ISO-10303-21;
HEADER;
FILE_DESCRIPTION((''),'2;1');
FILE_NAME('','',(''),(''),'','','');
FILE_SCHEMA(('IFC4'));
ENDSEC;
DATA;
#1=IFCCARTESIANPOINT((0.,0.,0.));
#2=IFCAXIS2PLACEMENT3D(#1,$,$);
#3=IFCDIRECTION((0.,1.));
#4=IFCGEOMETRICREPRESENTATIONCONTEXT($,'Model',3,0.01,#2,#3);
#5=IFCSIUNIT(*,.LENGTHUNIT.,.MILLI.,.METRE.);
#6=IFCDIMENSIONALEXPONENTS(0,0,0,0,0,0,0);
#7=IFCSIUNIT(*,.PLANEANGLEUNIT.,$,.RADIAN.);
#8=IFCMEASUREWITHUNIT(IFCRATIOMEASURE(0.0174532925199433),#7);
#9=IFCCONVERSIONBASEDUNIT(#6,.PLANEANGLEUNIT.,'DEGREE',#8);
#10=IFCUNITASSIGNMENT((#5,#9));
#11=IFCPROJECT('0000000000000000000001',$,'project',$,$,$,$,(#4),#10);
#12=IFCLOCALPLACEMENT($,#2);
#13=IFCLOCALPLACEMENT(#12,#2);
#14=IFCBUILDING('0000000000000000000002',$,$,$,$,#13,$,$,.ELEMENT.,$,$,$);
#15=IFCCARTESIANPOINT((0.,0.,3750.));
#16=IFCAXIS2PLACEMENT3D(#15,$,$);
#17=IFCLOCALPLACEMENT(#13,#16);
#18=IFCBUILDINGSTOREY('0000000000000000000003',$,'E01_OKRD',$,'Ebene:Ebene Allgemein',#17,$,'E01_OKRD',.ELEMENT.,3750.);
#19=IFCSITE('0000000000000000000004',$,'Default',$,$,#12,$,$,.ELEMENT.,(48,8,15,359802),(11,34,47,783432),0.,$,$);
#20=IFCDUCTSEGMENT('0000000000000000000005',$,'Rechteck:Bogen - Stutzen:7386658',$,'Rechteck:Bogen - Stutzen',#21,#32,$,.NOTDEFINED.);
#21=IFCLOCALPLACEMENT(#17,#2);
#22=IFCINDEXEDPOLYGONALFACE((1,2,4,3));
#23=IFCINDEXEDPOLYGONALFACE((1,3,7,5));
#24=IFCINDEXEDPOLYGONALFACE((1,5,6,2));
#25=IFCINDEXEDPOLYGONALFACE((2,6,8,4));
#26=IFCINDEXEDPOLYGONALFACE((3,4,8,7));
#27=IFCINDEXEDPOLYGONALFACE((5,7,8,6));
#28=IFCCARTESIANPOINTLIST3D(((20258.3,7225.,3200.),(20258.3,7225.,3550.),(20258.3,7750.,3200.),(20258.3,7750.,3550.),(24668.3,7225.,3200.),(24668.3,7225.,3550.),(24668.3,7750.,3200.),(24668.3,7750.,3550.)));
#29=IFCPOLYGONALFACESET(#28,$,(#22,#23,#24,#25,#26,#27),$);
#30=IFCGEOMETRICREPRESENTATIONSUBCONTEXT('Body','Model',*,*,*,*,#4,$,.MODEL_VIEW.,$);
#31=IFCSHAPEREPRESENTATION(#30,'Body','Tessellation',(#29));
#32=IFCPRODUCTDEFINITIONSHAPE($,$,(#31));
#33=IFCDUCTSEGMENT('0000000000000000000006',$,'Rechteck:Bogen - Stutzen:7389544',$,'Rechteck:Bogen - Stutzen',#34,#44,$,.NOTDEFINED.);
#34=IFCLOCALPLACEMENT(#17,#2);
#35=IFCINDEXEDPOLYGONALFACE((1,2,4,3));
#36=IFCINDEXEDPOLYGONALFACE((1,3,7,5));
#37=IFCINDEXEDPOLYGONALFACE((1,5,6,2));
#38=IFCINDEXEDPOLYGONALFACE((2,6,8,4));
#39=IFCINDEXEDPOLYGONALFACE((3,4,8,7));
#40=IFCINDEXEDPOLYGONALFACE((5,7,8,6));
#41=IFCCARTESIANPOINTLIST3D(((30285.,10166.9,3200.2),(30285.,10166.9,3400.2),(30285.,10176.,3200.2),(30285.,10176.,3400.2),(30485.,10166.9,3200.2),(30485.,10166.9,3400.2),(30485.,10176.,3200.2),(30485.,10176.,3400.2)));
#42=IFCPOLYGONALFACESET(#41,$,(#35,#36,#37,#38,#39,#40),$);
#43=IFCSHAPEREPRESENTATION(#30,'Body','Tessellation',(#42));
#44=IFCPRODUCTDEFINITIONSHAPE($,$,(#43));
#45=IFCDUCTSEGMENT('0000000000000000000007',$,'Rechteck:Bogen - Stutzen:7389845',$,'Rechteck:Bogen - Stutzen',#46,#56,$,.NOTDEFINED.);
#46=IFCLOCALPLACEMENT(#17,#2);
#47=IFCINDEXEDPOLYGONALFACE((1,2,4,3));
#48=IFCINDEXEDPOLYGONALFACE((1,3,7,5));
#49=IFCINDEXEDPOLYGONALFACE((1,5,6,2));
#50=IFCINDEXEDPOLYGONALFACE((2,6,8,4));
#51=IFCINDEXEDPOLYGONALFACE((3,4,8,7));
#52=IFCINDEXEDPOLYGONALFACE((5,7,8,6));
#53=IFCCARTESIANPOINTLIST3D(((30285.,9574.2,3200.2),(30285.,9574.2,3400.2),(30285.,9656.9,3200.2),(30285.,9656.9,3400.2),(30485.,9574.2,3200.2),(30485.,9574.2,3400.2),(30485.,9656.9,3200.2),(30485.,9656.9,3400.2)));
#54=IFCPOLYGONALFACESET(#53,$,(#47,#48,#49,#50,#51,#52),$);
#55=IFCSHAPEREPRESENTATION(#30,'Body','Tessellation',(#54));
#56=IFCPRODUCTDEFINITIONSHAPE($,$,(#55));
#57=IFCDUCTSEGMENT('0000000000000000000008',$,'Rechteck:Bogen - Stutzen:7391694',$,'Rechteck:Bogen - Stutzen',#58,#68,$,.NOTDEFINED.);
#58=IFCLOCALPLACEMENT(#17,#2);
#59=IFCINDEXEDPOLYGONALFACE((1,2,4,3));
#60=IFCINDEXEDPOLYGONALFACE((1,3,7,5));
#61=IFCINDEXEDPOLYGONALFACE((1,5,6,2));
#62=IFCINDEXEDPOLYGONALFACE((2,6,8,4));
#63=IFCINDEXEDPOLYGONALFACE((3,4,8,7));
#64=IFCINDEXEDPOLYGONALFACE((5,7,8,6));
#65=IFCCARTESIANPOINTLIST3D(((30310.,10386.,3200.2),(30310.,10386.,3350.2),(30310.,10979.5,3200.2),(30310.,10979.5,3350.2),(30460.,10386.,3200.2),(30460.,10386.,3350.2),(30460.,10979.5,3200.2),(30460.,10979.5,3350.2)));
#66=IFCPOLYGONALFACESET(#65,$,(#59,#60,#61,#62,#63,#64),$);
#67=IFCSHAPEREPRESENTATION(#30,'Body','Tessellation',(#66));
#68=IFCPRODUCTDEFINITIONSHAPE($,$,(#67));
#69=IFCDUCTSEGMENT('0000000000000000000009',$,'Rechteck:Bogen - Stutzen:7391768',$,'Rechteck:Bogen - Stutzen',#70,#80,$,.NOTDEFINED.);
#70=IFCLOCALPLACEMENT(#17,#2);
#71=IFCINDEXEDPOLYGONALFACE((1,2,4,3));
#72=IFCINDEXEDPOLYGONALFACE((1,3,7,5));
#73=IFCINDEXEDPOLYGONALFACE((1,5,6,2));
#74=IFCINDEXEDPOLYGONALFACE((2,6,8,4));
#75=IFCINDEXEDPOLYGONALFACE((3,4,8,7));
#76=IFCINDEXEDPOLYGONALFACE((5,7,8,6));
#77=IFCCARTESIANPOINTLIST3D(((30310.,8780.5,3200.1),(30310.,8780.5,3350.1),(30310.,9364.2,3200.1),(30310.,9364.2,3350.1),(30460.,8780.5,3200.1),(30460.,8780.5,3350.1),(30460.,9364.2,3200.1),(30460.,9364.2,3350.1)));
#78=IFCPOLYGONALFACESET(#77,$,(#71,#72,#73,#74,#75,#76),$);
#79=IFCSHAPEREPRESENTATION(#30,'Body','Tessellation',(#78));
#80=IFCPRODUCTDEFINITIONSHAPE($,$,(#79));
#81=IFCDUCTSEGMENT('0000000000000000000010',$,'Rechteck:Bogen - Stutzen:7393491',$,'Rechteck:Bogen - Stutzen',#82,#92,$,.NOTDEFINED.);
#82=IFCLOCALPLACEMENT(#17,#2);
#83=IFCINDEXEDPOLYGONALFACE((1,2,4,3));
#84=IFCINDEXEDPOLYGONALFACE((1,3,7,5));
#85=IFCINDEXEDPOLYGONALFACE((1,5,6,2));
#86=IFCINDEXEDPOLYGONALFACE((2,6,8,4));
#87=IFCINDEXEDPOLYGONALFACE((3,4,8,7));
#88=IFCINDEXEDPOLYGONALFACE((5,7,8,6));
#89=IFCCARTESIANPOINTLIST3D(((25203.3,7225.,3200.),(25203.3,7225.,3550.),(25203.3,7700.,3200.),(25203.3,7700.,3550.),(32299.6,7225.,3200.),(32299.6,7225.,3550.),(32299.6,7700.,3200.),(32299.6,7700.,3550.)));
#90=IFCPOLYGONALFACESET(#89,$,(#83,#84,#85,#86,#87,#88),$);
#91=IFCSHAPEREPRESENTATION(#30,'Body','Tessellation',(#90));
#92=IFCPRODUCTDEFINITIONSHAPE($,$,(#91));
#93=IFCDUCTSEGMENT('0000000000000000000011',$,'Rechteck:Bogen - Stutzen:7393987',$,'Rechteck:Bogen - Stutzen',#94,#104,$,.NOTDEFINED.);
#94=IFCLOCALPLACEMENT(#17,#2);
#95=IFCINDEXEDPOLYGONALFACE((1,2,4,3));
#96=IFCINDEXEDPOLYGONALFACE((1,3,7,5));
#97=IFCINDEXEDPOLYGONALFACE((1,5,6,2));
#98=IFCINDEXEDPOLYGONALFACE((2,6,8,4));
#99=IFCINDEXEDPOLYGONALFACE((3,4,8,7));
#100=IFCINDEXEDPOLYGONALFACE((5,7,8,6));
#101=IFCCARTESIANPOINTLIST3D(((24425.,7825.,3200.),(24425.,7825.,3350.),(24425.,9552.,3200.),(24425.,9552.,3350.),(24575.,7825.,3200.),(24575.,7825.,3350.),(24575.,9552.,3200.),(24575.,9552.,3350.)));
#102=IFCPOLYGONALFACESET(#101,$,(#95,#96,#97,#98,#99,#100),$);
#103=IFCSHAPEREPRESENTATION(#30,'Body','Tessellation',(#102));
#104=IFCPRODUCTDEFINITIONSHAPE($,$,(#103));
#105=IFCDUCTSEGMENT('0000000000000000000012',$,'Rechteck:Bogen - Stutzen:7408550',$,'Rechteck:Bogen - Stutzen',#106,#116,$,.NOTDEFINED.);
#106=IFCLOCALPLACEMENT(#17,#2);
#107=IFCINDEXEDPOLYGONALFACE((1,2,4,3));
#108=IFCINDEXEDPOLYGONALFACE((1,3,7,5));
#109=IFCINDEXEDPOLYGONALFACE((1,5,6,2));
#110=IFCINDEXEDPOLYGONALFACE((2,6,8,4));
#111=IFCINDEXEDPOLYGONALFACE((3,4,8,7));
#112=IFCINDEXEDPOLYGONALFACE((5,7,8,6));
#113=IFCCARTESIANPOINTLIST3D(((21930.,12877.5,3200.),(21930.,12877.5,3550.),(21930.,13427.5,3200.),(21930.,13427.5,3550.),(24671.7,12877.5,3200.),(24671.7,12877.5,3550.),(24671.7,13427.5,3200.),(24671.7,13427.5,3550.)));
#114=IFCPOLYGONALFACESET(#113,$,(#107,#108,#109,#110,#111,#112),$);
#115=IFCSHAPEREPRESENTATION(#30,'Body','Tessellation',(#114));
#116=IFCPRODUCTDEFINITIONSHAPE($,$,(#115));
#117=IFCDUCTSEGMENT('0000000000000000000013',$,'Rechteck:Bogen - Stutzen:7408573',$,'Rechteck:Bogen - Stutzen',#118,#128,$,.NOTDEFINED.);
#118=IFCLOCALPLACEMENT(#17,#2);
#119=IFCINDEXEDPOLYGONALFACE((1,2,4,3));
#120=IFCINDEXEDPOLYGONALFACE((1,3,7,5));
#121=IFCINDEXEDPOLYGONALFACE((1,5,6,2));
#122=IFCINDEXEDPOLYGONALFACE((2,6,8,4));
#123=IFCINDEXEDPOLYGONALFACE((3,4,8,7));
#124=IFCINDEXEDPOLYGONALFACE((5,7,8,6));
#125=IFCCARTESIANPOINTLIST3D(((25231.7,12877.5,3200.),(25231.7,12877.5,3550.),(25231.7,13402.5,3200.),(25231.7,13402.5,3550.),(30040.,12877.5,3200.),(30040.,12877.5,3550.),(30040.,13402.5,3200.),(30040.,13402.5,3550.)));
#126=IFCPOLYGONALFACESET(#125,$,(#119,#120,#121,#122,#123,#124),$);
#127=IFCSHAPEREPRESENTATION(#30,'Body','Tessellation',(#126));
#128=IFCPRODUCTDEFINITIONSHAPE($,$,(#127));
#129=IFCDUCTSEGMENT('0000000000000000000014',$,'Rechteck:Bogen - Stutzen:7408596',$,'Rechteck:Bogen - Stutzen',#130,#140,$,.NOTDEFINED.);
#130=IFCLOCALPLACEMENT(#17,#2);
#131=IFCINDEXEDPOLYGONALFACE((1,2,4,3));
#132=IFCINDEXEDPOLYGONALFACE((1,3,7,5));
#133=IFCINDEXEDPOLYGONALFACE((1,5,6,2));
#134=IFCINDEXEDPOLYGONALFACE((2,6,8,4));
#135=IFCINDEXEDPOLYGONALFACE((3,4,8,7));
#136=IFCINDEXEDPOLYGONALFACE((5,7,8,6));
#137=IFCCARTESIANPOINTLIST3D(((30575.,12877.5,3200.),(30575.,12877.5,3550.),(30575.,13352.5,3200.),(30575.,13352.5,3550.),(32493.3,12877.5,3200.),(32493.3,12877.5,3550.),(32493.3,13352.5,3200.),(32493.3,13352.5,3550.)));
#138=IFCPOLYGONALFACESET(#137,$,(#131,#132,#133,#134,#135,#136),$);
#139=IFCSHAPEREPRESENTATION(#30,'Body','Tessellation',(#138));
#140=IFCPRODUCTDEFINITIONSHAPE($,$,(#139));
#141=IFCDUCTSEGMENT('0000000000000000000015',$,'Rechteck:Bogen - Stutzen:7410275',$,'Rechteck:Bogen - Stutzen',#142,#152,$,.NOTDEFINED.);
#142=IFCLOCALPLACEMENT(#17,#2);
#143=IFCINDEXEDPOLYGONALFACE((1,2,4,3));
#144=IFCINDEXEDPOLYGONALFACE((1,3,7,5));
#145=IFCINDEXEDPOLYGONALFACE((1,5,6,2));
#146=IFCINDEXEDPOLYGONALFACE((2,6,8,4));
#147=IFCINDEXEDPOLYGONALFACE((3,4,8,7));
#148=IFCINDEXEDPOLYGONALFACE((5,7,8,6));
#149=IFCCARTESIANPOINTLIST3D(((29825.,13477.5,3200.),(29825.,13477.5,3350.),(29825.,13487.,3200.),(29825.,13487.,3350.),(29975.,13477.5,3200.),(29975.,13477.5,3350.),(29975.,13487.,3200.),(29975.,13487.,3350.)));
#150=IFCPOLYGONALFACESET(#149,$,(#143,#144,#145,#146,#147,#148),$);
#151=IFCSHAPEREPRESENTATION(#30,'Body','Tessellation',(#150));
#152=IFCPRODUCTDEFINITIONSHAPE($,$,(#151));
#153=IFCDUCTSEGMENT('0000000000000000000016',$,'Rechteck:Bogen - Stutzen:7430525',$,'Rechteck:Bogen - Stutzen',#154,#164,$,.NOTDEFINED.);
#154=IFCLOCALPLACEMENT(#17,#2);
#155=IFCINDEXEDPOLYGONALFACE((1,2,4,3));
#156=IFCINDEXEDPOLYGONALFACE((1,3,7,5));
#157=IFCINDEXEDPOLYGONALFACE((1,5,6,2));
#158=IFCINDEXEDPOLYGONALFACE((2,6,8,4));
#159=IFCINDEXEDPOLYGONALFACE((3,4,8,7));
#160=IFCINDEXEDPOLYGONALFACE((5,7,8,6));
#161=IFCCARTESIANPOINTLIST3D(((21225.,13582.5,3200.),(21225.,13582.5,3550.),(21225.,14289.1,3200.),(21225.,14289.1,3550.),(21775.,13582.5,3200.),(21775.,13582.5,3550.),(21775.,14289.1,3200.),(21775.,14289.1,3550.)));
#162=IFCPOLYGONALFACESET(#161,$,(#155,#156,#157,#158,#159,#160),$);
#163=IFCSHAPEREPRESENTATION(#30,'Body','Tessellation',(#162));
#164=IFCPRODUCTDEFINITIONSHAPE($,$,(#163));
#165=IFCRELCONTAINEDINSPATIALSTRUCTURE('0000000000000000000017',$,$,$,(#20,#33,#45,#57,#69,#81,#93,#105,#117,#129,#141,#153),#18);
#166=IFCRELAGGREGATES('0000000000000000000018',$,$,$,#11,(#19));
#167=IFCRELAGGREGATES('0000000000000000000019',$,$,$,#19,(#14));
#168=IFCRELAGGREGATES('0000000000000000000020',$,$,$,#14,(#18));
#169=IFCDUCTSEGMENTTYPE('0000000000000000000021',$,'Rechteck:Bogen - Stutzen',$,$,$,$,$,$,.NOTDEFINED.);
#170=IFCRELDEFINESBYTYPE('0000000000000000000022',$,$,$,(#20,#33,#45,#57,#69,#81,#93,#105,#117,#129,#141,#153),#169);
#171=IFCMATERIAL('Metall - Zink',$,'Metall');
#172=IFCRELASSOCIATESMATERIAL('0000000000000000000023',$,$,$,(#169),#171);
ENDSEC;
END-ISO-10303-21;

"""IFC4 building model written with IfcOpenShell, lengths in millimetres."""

from ifc_helpers import new_model, entity, si_unit, converted_unit, direction, frame, frame_2d, origin, origin_2d_with_axis, place, context, subcontext, project, spatial, rectangle, extrude, material, type_object, element, save


model = new_model("IFC4")

# Units and contexts
model_context = context("Model", 3, precision=0.01, world=origin(), true_north=direction((0.0, 1.0)))
body_context = subcontext(model_context, "Body", "Model", "MODEL_VIEW")
ifc_project = project(units=[si_unit("LENGTHUNIT", "METRE", prefix="MILLI"), converted_unit("PLANEANGLEUNIT", "DEGREE", entity("IfcRatioMeasure", 0.0174532925199433), si_unit("PLANEANGLEUNIT", "RADIAN"), dimensions=[0, 0, 0, 0, 0, 0, 0])], contexts=[model_context])

# Site, building, storey
site_placement = place(None, origin())
site = spatial("IfcSite", under=ifc_project, at=site_placement, Name="Default", CompositionType="ELEMENT", RefLatitude=(48, 8, 15, 359802), RefLongitude=(11, 34, 47, 783432), RefElevation=0.0)
building_placement = place(site_placement, origin())
building = spatial("IfcBuilding", under=site, at=building_placement, CompositionType="ELEMENT")
storey_placement = place(building_placement, frame((0.0, 0.0, 3750.0)))
storey = spatial("IfcBuildingStorey", under=building, at=storey_placement, Name="E01_OKRD", ObjectType="Ebene:Ebene Allgemein", LongName="E01_OKRD", CompositionType="ELEMENT", Elevation=3750.0)

# Duct segments
ifc_material_1 = material(Name="Metall - Zink", Category="Metall")
duct_segment_type_1 = type_object("IfcDuctSegmentType", Name="Rechteck:Bogen - Stutzen", PredefinedType="NOTDEFINED", material=ifc_material_1)
duct_segment_1_placement = place(storey_placement, frame((20258.3, 7225.0, 3200.0)))
element("IfcDuctSegment", 1, at=duct_segment_1_placement, inside=storey, type_object=duct_segment_type_1, Name="Rechteck:Bogen - Stutzen:7386658", ObjectType="Rechteck:Bogen - Stutzen", PredefinedType="NOTDEFINED", context=body_context, shape_type="SweptSolid", body=[
    extrude(rectangle(XDim=4410.0, YDim=525.0, at=frame_2d((0.0, 0.0), x_axis=(1.0, 0.0))), frame((2205.0, 262.5, 0.0), z_axis=(0.0, 0.0, 1.0), x_axis=(-1.0, 0.0, 0.0)), (0.0, 0.0, 1.0), 350.0),
])
duct_segment_2_placement = place(storey_placement, frame((30285.0, 10166.9, 3200.2)))
element("IfcDuctSegment", 2, at=duct_segment_2_placement, inside=storey, type_object=duct_segment_type_1, Name="Rechteck:Bogen - Stutzen:7389544", ObjectType="Rechteck:Bogen - Stutzen", PredefinedType="NOTDEFINED", context=body_context, shape_type="SweptSolid", body=[
    extrude(rectangle(XDim=9.1, YDim=200.0, at=frame_2d((0.0, 0.0), x_axis=(1.0, 0.0))), frame((100.0, 4.6, 0.0), z_axis=(0.0, 0.0, 1.0), x_axis=(0.0, 1.0, 0.0)), (0.0, 0.0, 1.0), 200.0),
])
duct_segment_3_placement = place(storey_placement, frame((30285.0, 9574.2, 3200.2)))
element("IfcDuctSegment", 3, at=duct_segment_3_placement, inside=storey, type_object=duct_segment_type_1, Name="Rechteck:Bogen - Stutzen:7389845", ObjectType="Rechteck:Bogen - Stutzen", PredefinedType="NOTDEFINED", context=body_context, shape_type="SweptSolid", body=[
    extrude(rectangle(XDim=82.7, YDim=200.0, at=origin_2d_with_axis()), frame((100.0, 41.3, 0.0), z_axis=(0.0, 0.0, 1.0), x_axis=(0.0, -1.0, 0.0)), (0.0, 0.0, 1.0), 200.0),
])
duct_segment_4_placement = place(storey_placement, frame((30310.0, 10386.0, 3200.2)))
element("IfcDuctSegment", 4, at=duct_segment_4_placement, inside=storey, type_object=duct_segment_type_1, Name="Rechteck:Bogen - Stutzen:7391694", ObjectType="Rechteck:Bogen - Stutzen", PredefinedType="NOTDEFINED", context=body_context, shape_type="SweptSolid", body=[
    extrude(rectangle(XDim=593.5, YDim=150.0, at=frame_2d((0.0, 0.0), x_axis=(1.0, 0.0))), frame((75.0, 296.8, 0.0), z_axis=(0.0, 0.0, 1.0), x_axis=(0.0, -1.0, 0.0)), (0.0, 0.0, 1.0), 150.0),
])
duct_segment_5_placement = place(storey_placement, frame((30310.0, 8780.5, 3200.1)))
element("IfcDuctSegment", 5, at=duct_segment_5_placement, inside=storey, type_object=duct_segment_type_1, Name="Rechteck:Bogen - Stutzen:7391768", ObjectType="Rechteck:Bogen - Stutzen", PredefinedType="NOTDEFINED", context=body_context, shape_type="SweptSolid", body=[
    extrude(rectangle(XDim=583.7, YDim=150.0, at=origin_2d_with_axis()), frame((75.0, 291.9, 0.0), z_axis=(0.0, 0.0, 1.0), x_axis=(0.0, 1.0, 0.0)), (0.0, 0.0, 1.0), 150.0),
])
duct_segment_6_placement = place(storey_placement, frame((25203.3, 7225.0, 3200.0)))
element("IfcDuctSegment", 6, at=duct_segment_6_placement, inside=storey, type_object=duct_segment_type_1, Name="Rechteck:Bogen - Stutzen:7393491", ObjectType="Rechteck:Bogen - Stutzen", PredefinedType="NOTDEFINED", context=body_context, shape_type="SweptSolid", body=[
    extrude(rectangle(XDim=7096.2, YDim=475.0, at=frame_2d((0.0, 0.0), x_axis=(1.0, 0.0))), frame((3548.1, 237.5, 0.0)), (0.0, 0.0, 1.0), 350.0),
])
duct_segment_7_placement = place(storey_placement, frame((24425.0, 7825.0, 3200.0)))
element("IfcDuctSegment", 7, at=duct_segment_7_placement, inside=storey, type_object=duct_segment_type_1, Name="Rechteck:Bogen - Stutzen:7393987", ObjectType="Rechteck:Bogen - Stutzen", PredefinedType="NOTDEFINED", context=body_context, shape_type="SweptSolid", body=[
    extrude(rectangle(XDim=1727.0, YDim=150.0, at=frame_2d((0.0, 0.0), x_axis=(1.0, 0.0))), frame((75.0, 863.5, 0.0), z_axis=(0.0, -0.000024, 1.0), x_axis=(0.0, -1.0, -0.000024)), (0.0, 0.0, 1.0), 150.0),
])
duct_segment_8_placement = place(storey_placement, frame((21930.0, 12877.5, 3200.0)))
element("IfcDuctSegment", 8, at=duct_segment_8_placement, inside=storey, type_object=duct_segment_type_1, Name="Rechteck:Bogen - Stutzen:7408550", ObjectType="Rechteck:Bogen - Stutzen", PredefinedType="NOTDEFINED", context=body_context, shape_type="SweptSolid", body=[
    extrude(rectangle(XDim=2741.8, YDim=550.0, at=frame_2d((0.0, 0.0), x_axis=(1.0, 0.0))), frame((1370.9, 275.0, 0.0), z_axis=(0.0, 0.0, 1.0), x_axis=(-1.0, 0.0, 0.0)), (0.0, 0.0, 1.0), 350.0),
])
duct_segment_9_placement = place(storey_placement, frame((25231.7, 12877.5, 3200.0)))
element("IfcDuctSegment", 9, at=duct_segment_9_placement, inside=storey, type_object=duct_segment_type_1, Name="Rechteck:Bogen - Stutzen:7408573", ObjectType="Rechteck:Bogen - Stutzen", PredefinedType="NOTDEFINED", context=body_context, shape_type="SweptSolid", body=[
    extrude(rectangle(XDim=4808.2, YDim=525.0, at=origin_2d_with_axis()), frame((2404.1, 262.5, 0.0), z_axis=(0.0, 0.0, 1.0), x_axis=(-1.0, 0.0, 0.0)), (0.0, 0.0, 1.0), 350.0),
])
duct_segment_10_placement = place(storey_placement, frame((30575.0, 12877.5, 3200.0)))
element("IfcDuctSegment", 10, at=duct_segment_10_placement, inside=storey, type_object=duct_segment_type_1, Name="Rechteck:Bogen - Stutzen:7408596", ObjectType="Rechteck:Bogen - Stutzen", PredefinedType="NOTDEFINED", context=body_context, shape_type="SweptSolid", body=[
    extrude(rectangle(XDim=1918.3, YDim=475.0, at=frame_2d((0.0, 0.0), x_axis=(1.0, 0.0))), frame((959.2, 237.5, 0.0), z_axis=(0.0, 0.0, 1.0), x_axis=(-1.0, 0.0, 0.0)), (0.0, 0.0, 1.0), 350.0),
])
duct_segment_11_placement = place(storey_placement, frame((29825.0, 13477.5, 3200.0)))
element("IfcDuctSegment", 11, at=duct_segment_11_placement, inside=storey, type_object=duct_segment_type_1, Name="Rechteck:Bogen - Stutzen:7410275", ObjectType="Rechteck:Bogen - Stutzen", PredefinedType="NOTDEFINED", context=body_context, shape_type="SweptSolid", body=[
    extrude(rectangle(XDim=9.5, YDim=150.0, at=frame_2d((0.0, 0.0), x_axis=(1.0, 0.0))), frame((75.0, 4.8, 0.0), z_axis=(0.0, 0.0, 1.0), x_axis=(0.0, -1.0, 0.0)), (0.0, 0.0, 1.0), 150.0),
])
duct_segment_12_placement = place(storey_placement, frame((21225.0, 13582.5, 3200.0)))
element("IfcDuctSegment", 12, at=duct_segment_12_placement, inside=storey, type_object=duct_segment_type_1, Name="Rechteck:Bogen - Stutzen:7430525", ObjectType="Rechteck:Bogen - Stutzen", PredefinedType="NOTDEFINED", context=body_context, shape_type="SweptSolid", body=[
    extrude(rectangle(XDim=706.6, YDim=550.0, at=frame_2d((0.0, 0.0), x_axis=(1.0, 0.0))), frame((275.0, 353.3, 0.0), z_axis=(0.0, 0.0, 1.0), x_axis=(0.0, -1.0, 0.0)), (0.0, 0.0, 1.0), 350.0),
])

save(model, "model.ifc")
